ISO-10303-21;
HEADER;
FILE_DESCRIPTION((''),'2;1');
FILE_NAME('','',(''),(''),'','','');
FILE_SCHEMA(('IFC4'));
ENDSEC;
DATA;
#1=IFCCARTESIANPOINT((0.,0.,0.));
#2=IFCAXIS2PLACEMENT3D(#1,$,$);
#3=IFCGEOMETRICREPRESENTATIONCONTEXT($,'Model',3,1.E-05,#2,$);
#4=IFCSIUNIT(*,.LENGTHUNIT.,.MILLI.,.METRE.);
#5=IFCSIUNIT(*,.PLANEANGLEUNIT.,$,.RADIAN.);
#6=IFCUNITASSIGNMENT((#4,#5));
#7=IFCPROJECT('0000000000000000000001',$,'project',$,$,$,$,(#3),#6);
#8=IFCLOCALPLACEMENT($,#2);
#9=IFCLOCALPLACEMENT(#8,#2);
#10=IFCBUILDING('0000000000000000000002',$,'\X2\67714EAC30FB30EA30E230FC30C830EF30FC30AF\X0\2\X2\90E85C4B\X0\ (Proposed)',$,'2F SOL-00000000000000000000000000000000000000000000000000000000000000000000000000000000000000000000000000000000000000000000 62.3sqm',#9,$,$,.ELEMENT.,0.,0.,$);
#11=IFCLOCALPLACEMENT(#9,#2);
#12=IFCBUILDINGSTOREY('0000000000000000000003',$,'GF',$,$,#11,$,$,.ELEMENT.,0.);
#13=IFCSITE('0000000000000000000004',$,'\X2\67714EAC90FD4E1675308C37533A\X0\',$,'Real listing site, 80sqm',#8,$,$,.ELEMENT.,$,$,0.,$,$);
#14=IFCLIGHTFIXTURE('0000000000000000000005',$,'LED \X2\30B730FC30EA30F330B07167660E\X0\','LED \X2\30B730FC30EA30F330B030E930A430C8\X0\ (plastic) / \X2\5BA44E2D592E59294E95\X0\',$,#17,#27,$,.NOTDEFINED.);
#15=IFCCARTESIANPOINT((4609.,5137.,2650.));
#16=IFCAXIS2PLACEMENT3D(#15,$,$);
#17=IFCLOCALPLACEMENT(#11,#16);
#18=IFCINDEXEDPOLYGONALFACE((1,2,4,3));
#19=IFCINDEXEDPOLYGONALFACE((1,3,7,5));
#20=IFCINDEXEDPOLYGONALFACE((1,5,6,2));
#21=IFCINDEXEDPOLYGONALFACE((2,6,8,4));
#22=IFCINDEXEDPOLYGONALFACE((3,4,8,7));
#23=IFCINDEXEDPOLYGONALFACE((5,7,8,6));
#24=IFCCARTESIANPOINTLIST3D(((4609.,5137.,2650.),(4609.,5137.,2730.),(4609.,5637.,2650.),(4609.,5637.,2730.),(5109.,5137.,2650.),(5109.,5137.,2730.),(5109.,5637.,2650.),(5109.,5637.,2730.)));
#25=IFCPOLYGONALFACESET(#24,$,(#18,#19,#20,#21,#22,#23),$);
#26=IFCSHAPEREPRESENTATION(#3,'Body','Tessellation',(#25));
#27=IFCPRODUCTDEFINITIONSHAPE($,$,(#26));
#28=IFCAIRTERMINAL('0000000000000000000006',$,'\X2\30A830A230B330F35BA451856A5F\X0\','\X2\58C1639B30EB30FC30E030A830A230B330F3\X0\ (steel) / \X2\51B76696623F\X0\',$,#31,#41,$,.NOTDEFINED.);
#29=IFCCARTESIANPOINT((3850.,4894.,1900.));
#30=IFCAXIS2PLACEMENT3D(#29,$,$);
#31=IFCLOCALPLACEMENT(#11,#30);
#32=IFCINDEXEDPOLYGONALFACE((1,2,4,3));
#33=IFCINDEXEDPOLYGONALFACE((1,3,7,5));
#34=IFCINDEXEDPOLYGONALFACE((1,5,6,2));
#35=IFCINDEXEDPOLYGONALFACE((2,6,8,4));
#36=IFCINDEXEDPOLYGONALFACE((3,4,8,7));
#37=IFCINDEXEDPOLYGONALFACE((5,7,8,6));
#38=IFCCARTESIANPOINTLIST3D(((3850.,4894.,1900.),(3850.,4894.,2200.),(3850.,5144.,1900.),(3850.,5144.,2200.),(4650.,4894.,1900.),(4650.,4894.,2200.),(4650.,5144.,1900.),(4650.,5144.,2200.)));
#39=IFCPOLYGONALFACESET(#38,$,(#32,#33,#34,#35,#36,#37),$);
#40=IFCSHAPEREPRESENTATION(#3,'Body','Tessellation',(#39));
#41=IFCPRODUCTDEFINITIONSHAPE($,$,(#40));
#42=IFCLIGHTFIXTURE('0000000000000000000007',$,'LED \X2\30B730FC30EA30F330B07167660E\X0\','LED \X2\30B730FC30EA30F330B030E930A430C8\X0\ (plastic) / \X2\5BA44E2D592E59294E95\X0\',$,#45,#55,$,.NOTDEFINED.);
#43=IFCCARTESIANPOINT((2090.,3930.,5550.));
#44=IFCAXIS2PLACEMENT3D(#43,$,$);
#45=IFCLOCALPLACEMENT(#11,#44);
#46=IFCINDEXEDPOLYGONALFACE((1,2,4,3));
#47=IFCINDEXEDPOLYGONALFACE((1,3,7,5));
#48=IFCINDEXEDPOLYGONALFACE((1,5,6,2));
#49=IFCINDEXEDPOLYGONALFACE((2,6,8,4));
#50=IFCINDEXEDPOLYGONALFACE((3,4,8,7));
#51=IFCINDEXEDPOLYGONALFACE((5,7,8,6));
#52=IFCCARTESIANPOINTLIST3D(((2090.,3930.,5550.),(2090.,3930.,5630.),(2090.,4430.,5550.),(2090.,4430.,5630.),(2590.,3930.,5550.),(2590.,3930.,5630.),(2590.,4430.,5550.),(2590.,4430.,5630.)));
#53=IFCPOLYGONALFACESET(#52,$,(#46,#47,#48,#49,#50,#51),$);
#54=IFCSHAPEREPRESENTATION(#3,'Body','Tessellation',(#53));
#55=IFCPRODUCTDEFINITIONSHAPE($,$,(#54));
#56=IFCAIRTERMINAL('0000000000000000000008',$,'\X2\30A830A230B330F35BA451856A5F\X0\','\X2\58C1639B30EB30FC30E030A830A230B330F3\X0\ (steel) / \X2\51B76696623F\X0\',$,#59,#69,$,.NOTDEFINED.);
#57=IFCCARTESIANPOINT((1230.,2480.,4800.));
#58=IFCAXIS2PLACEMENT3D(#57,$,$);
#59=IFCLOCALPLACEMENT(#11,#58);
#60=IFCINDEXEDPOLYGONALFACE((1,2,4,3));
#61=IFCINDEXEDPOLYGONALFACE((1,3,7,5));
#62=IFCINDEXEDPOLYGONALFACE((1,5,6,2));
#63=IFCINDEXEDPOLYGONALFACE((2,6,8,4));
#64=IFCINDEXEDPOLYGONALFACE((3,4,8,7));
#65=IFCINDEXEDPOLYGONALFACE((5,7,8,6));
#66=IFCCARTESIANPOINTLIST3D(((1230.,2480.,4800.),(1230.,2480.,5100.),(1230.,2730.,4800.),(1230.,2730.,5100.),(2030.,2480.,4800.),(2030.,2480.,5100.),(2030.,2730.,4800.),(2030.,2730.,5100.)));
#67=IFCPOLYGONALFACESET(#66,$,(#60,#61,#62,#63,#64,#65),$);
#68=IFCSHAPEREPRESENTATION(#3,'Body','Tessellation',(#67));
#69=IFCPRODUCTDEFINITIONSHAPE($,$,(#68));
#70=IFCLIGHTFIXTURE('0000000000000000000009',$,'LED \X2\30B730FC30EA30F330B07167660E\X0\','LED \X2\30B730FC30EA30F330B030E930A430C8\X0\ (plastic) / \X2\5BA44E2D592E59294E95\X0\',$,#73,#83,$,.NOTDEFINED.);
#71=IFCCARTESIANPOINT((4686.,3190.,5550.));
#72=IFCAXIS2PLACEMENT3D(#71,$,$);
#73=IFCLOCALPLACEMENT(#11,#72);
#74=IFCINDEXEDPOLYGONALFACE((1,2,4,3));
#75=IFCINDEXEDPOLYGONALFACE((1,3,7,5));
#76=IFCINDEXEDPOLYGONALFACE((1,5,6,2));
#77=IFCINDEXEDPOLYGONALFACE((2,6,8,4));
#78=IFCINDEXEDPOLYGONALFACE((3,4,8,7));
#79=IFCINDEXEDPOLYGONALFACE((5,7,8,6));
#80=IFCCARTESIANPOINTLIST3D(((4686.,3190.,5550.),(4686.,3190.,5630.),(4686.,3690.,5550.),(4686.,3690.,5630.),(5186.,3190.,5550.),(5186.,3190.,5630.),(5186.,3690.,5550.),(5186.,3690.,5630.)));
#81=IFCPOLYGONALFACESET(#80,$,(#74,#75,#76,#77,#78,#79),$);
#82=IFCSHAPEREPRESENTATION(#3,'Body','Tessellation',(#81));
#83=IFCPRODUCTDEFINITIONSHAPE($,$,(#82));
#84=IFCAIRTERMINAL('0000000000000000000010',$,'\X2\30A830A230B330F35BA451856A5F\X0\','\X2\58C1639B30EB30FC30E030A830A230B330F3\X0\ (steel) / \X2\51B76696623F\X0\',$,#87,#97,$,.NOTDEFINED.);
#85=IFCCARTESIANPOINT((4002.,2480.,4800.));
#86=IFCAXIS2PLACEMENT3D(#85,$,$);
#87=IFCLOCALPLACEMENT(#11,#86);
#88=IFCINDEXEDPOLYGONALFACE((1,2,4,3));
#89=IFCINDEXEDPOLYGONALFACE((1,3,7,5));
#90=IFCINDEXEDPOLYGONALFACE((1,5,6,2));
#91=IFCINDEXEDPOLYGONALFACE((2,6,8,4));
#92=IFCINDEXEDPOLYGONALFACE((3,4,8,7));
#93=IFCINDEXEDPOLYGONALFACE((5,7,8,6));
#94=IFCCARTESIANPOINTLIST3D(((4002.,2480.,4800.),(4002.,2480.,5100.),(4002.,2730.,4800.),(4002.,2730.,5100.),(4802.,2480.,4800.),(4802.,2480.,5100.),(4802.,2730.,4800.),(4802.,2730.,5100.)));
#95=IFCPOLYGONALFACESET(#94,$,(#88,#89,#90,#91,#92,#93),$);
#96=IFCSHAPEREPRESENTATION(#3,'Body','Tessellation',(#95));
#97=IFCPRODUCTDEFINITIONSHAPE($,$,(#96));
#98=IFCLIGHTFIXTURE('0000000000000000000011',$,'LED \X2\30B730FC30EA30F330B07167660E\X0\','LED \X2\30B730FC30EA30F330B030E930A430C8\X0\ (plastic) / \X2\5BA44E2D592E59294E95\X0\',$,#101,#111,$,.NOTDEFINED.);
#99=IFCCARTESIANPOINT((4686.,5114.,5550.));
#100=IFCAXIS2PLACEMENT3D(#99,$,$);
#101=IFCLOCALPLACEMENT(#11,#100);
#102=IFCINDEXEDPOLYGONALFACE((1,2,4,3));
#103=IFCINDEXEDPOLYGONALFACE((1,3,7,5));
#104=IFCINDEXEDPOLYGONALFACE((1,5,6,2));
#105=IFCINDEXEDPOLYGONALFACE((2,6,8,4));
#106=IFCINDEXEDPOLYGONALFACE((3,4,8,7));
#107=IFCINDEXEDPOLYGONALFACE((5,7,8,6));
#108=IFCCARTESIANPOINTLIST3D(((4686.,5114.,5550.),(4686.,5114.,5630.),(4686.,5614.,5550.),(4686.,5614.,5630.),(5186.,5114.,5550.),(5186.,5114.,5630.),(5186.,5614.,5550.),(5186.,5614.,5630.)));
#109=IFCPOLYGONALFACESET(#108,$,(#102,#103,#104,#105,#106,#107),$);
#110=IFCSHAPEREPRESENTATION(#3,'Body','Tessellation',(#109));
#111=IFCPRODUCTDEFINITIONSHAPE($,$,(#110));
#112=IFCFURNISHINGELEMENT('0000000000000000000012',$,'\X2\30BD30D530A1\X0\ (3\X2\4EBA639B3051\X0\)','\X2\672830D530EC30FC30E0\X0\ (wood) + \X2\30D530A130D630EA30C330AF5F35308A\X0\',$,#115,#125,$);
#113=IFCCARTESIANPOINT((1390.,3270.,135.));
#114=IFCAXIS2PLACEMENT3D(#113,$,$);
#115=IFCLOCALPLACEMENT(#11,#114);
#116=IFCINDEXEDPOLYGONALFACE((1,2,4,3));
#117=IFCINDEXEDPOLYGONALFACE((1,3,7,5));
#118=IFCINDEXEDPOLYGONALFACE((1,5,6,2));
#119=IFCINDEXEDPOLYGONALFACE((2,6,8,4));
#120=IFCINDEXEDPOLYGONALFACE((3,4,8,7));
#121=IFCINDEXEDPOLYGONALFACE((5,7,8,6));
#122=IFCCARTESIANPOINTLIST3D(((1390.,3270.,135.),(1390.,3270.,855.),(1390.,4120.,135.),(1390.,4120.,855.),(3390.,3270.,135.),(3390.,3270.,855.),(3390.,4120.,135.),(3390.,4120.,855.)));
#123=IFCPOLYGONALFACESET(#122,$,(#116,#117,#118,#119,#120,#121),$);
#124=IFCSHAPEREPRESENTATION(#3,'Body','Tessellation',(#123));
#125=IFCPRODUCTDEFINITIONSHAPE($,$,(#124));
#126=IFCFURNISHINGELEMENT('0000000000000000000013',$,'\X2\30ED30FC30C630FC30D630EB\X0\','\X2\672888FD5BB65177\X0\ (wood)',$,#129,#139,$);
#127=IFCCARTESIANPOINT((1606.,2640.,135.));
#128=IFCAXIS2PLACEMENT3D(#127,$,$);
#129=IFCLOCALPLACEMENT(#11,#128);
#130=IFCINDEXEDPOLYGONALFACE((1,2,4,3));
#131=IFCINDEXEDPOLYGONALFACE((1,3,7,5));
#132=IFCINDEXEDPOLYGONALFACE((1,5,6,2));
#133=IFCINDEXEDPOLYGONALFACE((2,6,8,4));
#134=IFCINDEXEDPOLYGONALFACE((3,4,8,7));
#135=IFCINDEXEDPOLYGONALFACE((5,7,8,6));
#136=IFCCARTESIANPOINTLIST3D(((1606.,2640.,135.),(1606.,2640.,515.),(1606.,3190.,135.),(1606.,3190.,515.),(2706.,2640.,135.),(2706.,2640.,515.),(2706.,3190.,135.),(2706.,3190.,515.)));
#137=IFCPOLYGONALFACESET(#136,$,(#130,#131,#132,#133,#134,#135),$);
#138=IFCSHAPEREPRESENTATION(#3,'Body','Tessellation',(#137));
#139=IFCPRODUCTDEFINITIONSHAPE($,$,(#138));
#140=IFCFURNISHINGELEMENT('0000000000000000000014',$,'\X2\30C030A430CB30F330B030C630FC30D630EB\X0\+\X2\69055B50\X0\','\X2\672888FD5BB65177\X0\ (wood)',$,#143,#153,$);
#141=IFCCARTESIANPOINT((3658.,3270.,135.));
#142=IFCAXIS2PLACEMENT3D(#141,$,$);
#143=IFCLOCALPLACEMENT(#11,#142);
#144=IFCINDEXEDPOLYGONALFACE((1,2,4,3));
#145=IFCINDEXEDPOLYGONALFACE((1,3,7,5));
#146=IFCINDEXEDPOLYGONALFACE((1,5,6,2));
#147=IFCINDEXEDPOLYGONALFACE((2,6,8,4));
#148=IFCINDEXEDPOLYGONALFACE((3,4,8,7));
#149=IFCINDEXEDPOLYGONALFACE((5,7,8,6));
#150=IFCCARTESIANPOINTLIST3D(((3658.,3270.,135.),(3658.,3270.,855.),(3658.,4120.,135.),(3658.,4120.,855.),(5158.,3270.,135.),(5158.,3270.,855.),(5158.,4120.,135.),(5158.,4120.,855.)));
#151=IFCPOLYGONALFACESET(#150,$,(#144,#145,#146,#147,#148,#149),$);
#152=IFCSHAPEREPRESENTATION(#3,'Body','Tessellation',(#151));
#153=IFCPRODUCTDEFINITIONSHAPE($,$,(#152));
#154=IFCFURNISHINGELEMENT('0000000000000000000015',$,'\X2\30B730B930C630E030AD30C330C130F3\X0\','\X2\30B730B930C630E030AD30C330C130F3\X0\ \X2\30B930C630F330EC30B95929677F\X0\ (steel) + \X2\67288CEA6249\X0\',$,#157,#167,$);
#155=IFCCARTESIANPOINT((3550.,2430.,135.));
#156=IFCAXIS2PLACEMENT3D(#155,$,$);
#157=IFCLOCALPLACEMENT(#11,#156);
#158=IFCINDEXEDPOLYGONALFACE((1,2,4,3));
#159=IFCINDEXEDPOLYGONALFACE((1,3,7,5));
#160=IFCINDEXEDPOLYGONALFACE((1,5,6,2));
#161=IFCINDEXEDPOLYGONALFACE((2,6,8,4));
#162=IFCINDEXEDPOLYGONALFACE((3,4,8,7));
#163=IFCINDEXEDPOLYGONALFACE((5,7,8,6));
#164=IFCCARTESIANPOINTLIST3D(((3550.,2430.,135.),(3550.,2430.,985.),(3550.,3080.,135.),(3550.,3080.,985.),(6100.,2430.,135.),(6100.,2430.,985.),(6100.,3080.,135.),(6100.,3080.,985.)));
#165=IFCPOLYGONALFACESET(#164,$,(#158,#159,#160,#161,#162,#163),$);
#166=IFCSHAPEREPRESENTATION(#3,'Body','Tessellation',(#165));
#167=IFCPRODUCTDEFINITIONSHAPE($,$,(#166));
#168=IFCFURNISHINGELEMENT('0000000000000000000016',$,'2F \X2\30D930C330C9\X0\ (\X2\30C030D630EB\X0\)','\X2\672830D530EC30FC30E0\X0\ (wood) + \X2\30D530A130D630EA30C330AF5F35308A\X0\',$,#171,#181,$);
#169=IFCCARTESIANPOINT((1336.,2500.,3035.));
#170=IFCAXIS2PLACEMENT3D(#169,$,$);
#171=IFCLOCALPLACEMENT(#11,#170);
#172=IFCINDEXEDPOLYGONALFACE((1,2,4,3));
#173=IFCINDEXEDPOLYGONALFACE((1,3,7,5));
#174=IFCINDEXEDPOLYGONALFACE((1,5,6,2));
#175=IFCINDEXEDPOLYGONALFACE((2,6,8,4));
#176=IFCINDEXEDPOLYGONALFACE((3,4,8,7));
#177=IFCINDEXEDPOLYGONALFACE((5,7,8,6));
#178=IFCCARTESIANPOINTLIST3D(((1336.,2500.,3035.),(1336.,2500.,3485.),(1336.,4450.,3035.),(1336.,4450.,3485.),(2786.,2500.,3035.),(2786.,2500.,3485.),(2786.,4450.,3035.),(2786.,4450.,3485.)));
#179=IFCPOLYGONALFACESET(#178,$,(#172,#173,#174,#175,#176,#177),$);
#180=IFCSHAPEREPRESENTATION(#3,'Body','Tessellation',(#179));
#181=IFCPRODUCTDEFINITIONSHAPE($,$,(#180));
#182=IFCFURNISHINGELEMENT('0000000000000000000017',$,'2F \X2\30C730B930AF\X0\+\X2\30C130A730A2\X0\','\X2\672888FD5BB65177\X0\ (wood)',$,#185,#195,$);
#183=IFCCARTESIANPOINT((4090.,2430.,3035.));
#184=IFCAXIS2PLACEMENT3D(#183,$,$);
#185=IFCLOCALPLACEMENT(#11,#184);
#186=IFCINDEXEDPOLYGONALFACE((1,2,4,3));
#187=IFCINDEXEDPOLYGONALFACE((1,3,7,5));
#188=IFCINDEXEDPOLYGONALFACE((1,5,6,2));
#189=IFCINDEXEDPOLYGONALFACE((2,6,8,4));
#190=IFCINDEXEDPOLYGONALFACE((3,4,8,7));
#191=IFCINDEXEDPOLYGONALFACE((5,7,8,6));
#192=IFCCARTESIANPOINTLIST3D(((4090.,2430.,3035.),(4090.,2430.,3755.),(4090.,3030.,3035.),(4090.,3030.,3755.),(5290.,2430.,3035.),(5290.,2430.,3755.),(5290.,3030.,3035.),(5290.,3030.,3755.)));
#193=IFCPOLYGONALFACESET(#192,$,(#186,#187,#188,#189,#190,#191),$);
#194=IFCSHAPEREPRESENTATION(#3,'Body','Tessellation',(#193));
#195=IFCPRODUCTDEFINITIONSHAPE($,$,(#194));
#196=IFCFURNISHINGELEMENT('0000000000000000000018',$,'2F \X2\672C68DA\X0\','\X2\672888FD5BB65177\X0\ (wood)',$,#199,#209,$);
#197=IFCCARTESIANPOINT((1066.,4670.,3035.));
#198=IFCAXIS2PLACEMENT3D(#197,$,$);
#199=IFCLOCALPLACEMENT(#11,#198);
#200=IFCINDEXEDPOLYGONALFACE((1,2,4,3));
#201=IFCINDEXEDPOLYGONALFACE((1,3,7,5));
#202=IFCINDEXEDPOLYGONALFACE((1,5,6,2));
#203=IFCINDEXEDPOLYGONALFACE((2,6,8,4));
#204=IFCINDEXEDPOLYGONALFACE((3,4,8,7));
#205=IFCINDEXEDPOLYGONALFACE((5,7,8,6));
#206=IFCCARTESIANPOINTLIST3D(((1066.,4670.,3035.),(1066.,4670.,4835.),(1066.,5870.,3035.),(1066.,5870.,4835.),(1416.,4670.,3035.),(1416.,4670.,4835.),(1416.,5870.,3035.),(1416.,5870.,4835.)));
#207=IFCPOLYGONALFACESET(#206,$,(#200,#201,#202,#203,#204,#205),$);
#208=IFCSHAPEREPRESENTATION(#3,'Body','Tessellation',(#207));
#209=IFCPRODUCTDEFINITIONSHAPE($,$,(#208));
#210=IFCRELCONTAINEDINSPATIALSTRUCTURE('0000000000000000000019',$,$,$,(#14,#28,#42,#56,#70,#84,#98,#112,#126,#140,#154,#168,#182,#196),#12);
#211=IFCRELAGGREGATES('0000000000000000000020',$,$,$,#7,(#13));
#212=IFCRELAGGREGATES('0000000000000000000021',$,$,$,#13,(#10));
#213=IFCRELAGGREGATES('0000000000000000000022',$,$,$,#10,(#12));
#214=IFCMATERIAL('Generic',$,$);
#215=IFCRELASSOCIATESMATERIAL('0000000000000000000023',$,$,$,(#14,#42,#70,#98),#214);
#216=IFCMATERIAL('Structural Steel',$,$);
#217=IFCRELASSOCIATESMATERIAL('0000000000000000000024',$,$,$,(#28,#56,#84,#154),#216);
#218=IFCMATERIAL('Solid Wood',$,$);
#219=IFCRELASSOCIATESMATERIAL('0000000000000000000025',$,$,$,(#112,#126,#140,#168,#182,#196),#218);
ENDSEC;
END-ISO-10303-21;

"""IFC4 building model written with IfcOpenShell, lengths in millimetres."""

from ifc_helpers import new_model, si_unit, frame, frame_2d, origin, place, context, project, spatial, rectangle, extrude, material, element, save


model = new_model("IFC4")

# Units and contexts
model_context = context("Model", 3, precision=1e-05, world=origin())
ifc_project = project(units=[si_unit("LENGTHUNIT", "METRE", prefix="MILLI"), si_unit("PLANEANGLEUNIT", "RADIAN")], contexts=[model_context])

# Site, building, storey
site_placement = place(None, origin())
site = spatial("IfcSite", under=ifc_project, at=site_placement, Name="東京都世田谷区", ObjectType="Real listing site, 80sqm", CompositionType="ELEMENT", RefElevation=0.0)
building_placement = place(site_placement, origin())
building = spatial("IfcBuilding", under=site, at=building_placement, Name="東京・リモートワーク2部屋 (Proposed)", ObjectType="2F SOL-00000000000000000000000000000000000000000000000000000000000000000000000000000000000000000000000000000000000000000000 62.3sqm", CompositionType="ELEMENT", ElevationOfRefHeight=0.0, ElevationOfTerrain=0.0)
storey_placement = place(building_placement, origin())
storey = spatial("IfcBuildingStorey", under=building, at=storey_placement, Name="GF", CompositionType="ELEMENT", Elevation=0.0)

# Shared definitions
ifc_material_1 = material(Name="Solid Wood")

# Shared definitions
ifc_material_2 = material(Name="Structural Steel")

# Shared definitions
ifc_material_3 = material(Name="Generic")

# Light fixture
light_fixture_1_placement = place(storey_placement, frame((4609.0, 5137.0, 2650.0)))
element("IfcLightFixture", 1, at=light_fixture_1_placement, inside=storey, material=ifc_material_3, Name="LED シーリング照明", Description="LED シーリングライト (plastic) / 室中央天井", PredefinedType="NOTDEFINED", context=model_context, shape_type="SweptSolid", body=[
    extrude(rectangle(XDim=500.0, YDim=500.0, at=frame_2d((250.0, 250.0))), frame((4609.0, 5137.0, 2650.0)), (0.0, 0.0, 1.0), 80.0),
])

# Air terminal
air_terminal_1_placement = place(storey_placement, frame((3850.0, 4894.0, 1900.0)))
element("IfcAirTerminal", 2, at=air_terminal_1_placement, inside=storey, material=ifc_material_2, Name="エアコン室内機", Description="壁掛ルームエアコン (steel) / 冷暖房", PredefinedType="NOTDEFINED", context=model_context, shape_type="SweptSolid", body=[
    extrude(rectangle(XDim=800.0, YDim=250.0, at=frame_2d((400.0, 125.0))), frame((3850.0, 4894.0, 1900.0)), (0.0, 0.0, 1.0), 300.0),
])

# Light fixture
light_fixture_2_placement = place(storey_placement, frame((2090.0, 3930.0, 5550.0)))
element("IfcLightFixture", 3, at=light_fixture_2_placement, inside=storey, material=ifc_material_3, Name="LED シーリング照明", Description="LED シーリングライト (plastic) / 室中央天井", PredefinedType="NOTDEFINED", context=model_context, shape_type="SweptSolid", body=[
    extrude(rectangle(XDim=500.0, YDim=500.0, at=frame_2d((250.0, 250.0))), frame((2090.0, 3930.0, 5550.0)), (0.0, 0.0, 1.0), 80.0),
])

# Air terminal
air_terminal_2_placement = place(storey_placement, frame((1230.0, 2480.0, 4800.0)))
element("IfcAirTerminal", 4, at=air_terminal_2_placement, inside=storey, material=ifc_material_2, Name="エアコン室内機", Description="壁掛ルームエアコン (steel) / 冷暖房", PredefinedType="NOTDEFINED", context=model_context, shape_type="SweptSolid", body=[
    extrude(rectangle(XDim=800.0, YDim=250.0, at=frame_2d((400.0, 125.0))), frame((1230.0, 2480.0, 4800.0)), (0.0, 0.0, 1.0), 300.0),
])

# Light fixture
light_fixture_3_placement = place(storey_placement, frame((4686.0, 3190.0, 5550.0)))
element("IfcLightFixture", 5, at=light_fixture_3_placement, inside=storey, material=ifc_material_3, Name="LED シーリング照明", Description="LED シーリングライト (plastic) / 室中央天井", PredefinedType="NOTDEFINED", context=model_context, shape_type="SweptSolid", body=[
    extrude(rectangle(XDim=500.0, YDim=500.0, at=frame_2d((250.0, 250.0))), frame((4686.0, 3190.0, 5550.0)), (0.0, 0.0, 1.0), 80.0),
])

# Air terminal
air_terminal_3_placement = place(storey_placement, frame((4002.0, 2480.0, 4800.0)))
element("IfcAirTerminal", 6, at=air_terminal_3_placement, inside=storey, material=ifc_material_2, Name="エアコン室内機", Description="壁掛ルームエアコン (steel) / 冷暖房", PredefinedType="NOTDEFINED", context=model_context, shape_type="SweptSolid", body=[
    extrude(rectangle(XDim=800.0, YDim=250.0, at=frame_2d((400.0, 125.0))), frame((4002.0, 2480.0, 4800.0)), (0.0, 0.0, 1.0), 300.0),
])

# Light fixture
light_fixture_4_placement = place(storey_placement, frame((4686.0, 5114.0, 5550.0)))
element("IfcLightFixture", 7, at=light_fixture_4_placement, inside=storey, material=ifc_material_3, Name="LED シーリング照明", Description="LED シーリングライト (plastic) / 室中央天井", PredefinedType="NOTDEFINED", context=model_context, shape_type="SweptSolid", body=[
    extrude(rectangle(XDim=500.0, YDim=500.0, at=frame_2d((250.0, 250.0))), frame((4686.0, 5114.0, 5550.0)), (0.0, 0.0, 1.0), 80.0),
])

# Furnishing elements
furnishing_1_placement = place(storey_placement, frame((1390.0, 3270.0, 135.0)))
element("IfcFurnishingElement", 8, at=furnishing_1_placement, inside=storey, material=ifc_material_1, Name="ソファ (3人掛け)", Description="木フレーム (wood) + ファブリック張り", context=model_context, shape_type="SweptSolid", body=[
    extrude(rectangle(XDim=2000.0, YDim=850.0, at=frame_2d((1000.0, 425.0))), frame((1390.0, 3270.0, 135.0)), (0.0, 0.0, 1.0), 720.0),
])
furnishing_2_placement = place(storey_placement, frame((1606.0, 2640.0, 135.0)))
element("IfcFurnishingElement", 9, at=furnishing_2_placement, inside=storey, material=ifc_material_1, Name="ローテーブル", Description="木製家具 (wood)", context=model_context, shape_type="SweptSolid", body=[
    extrude(rectangle(XDim=1100.0, YDim=550.0, at=frame_2d((550.0, 275.0))), frame((1606.0, 2640.0, 135.0)), (0.0, 0.0, 1.0), 380.0),
])
furnishing_3_placement = place(storey_placement, frame((3658.0, 3270.0, 135.0)))
element("IfcFurnishingElement", 10, at=furnishing_3_placement, inside=storey, material=ifc_material_1, Name="ダイニングテーブル+椅子", Description="木製家具 (wood)", context=model_context, shape_type="SweptSolid", body=[
    extrude(rectangle(XDim=1500.0, YDim=850.0, at=frame_2d((750.0, 425.0))), frame((3658.0, 3270.0, 135.0)), (0.0, 0.0, 1.0), 720.0),
])
furnishing_4_placement = place(storey_placement, frame((3550.0, 2430.0, 135.0)))
element("IfcFurnishingElement", 11, at=furnishing_4_placement, inside=storey, material=ifc_material_2, Name="システムキッチン", Description="システムキッチン ステンレス天板 (steel) + 木質扉", context=model_context, shape_type="SweptSolid", body=[
    extrude(rectangle(XDim=2550.0, YDim=650.0, at=frame_2d((1275.0, 325.0))), frame((3550.0, 2430.0, 135.0)), (0.0, 0.0, 1.0), 850.0),
])
furnishing_5_placement = place(storey_placement, frame((1336.0, 2500.0, 3035.0)))
element("IfcFurnishingElement", 12, at=furnishing_5_placement, inside=storey, material=ifc_material_1, Name="2F ベッド (ダブル)", Description="木フレーム (wood) + ファブリック張り", context=model_context, shape_type="SweptSolid", body=[
    extrude(rectangle(XDim=1450.0, YDim=1950.0, at=frame_2d((725.0, 975.0))), frame((1336.0, 2500.0, 3035.0)), (0.0, 0.0, 1.0), 450.0),
])
furnishing_6_placement = place(storey_placement, frame((4090.0, 2430.0, 3035.0)))
element("IfcFurnishingElement", 13, at=furnishing_6_placement, inside=storey, material=ifc_material_1, Name="2F デスク+チェア", Description="木製家具 (wood)", context=model_context, shape_type="SweptSolid", body=[
    extrude(rectangle(XDim=1200.0, YDim=600.0, at=frame_2d((600.0, 300.0))), frame((4090.0, 2430.0, 3035.0)), (0.0, 0.0, 1.0), 720.0),
])
furnishing_7_placement = place(storey_placement, frame((1066.0, 4670.0, 3035.0)))
element("IfcFurnishingElement", 14, at=furnishing_7_placement, inside=storey, material=ifc_material_1, Name="2F 本棚", Description="木製家具 (wood)", context=model_context, shape_type="SweptSolid", body=[
    extrude(rectangle(XDim=350.0, YDim=1200.0, at=frame_2d((175.0, 600.0))), frame((1066.0, 4670.0, 3035.0)), (0.0, 0.0, 1.0), 1800.0),
])

save(model, "model.ifc")
